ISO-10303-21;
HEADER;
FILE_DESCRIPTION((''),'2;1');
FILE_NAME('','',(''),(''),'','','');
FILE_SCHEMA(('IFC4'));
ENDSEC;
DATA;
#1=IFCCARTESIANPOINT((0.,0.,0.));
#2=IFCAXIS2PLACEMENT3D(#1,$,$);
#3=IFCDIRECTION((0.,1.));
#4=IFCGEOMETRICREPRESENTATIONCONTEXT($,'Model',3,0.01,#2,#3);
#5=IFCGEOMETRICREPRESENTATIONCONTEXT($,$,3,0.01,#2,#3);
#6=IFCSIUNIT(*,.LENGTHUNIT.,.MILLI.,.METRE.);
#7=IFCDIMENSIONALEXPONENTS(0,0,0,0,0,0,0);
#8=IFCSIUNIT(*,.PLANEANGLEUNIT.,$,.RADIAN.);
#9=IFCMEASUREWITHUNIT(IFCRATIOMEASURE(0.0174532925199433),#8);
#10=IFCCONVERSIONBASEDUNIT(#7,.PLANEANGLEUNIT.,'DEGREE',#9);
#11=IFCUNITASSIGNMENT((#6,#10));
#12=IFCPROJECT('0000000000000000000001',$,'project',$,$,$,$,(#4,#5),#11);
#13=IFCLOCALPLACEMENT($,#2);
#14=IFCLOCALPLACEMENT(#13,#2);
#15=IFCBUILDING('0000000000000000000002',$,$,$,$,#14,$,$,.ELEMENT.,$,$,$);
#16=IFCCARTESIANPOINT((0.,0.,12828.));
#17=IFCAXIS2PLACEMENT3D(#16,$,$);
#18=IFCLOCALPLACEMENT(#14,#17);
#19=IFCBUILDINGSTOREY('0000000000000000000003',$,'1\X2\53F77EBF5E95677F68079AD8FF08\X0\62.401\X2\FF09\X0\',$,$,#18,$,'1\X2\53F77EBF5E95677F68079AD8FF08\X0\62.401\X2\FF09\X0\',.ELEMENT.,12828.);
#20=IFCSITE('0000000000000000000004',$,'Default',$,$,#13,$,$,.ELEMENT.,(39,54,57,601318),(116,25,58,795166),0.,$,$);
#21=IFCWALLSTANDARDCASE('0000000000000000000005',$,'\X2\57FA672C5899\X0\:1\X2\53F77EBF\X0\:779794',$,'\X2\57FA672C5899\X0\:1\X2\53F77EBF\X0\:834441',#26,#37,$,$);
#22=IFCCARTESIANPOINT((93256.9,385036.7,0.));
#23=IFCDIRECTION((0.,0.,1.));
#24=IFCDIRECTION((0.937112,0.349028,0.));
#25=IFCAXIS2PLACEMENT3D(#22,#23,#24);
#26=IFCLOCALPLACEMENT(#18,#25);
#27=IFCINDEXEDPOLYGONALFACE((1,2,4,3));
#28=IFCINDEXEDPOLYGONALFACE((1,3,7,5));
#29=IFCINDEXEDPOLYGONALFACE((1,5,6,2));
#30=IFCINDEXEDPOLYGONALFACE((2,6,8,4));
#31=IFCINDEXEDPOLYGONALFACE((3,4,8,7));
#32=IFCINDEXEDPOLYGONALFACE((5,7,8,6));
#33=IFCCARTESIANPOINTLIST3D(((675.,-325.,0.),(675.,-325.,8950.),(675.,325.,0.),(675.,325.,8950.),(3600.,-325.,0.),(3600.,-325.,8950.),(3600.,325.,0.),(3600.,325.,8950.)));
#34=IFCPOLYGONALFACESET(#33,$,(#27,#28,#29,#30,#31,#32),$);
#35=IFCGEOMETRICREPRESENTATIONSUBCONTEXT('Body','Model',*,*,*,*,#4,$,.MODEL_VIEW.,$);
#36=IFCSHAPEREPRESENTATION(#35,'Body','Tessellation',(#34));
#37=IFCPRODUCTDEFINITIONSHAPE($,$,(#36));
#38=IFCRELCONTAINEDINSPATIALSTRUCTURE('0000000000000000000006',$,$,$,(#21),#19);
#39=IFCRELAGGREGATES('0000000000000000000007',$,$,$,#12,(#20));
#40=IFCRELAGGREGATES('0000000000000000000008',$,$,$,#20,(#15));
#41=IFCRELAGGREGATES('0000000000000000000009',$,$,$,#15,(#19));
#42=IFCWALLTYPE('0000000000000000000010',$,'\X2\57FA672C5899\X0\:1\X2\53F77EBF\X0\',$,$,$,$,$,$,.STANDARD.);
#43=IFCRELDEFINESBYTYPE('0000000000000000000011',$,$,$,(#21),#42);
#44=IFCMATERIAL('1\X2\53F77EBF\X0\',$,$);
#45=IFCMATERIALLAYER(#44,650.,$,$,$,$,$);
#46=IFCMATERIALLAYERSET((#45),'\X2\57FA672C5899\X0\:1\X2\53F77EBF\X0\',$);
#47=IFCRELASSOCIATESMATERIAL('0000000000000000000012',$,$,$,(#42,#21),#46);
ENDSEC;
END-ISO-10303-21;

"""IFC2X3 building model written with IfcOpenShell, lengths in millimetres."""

from ifc_helpers import new_model, entity, si_unit, converted_unit, direction, frame, frame_2d, origin, place, context, subcontext, project, spatial, rectangle, extrude, material, layer, layer_set, layer_usage, type_object, element, save


model = new_model("IFC2X3")

# Units and contexts
model_context = context("Model", 3, precision=0.01, world=origin(), true_north=direction((0.0, 1.0)))
context_of_model = context(None, 3, precision=0.01, world=origin(), true_north=direction((0.0, 1.0)))
body_context = subcontext(model_context, "Body", "Model", "MODEL_VIEW")
ifc_project = project(units=[si_unit("LENGTHUNIT", "METRE", prefix="MILLI"), converted_unit("PLANEANGLEUNIT", "DEGREE", entity("IfcRatioMeasure", 0.0174532925199433), si_unit("PLANEANGLEUNIT", "RADIAN"), dimensions=[0, 0, 0, 0, 0, 0, 0])], contexts=[model_context, context_of_model])

# Site, building, storey
site_placement = place(None, origin())
site = spatial("IfcSite", under=ifc_project, at=site_placement, Name="Default", CompositionType="ELEMENT", RefLatitude=(39, 54, 57, 601318), RefLongitude=(116, 25, 58, 795166), RefElevation=0.0)
building_placement = place(site_placement, origin())
building = spatial("IfcBuilding", under=site, at=building_placement, CompositionType="ELEMENT")
storey_placement = place(building_placement, frame((0.0, 0.0, 12828.0)))
storey = spatial("IfcBuildingStorey", under=building, at=storey_placement, Name="1号线底板标高（62.401）", LongName="1号线底板标高（62.401）", CompositionType="ELEMENT", Elevation=12828.0)

# Wall
ifc_material_1 = material(Name="1号线")
ifc_layer = layer(ifc_material_1, 650.0)
ifc_layer_set = layer_set([ifc_layer], Name="基本墙:1号线")
wall_type = type_object("IfcWallType", Name="基本墙:1号线", PredefinedType="STANDARD", material=ifc_layer_set)
ifc_layer_usage_1 = layer_usage(ifc_layer_set, "AXIS2", "NEGATIVE", 325.0)
wall_1_placement = place(storey_placement, frame((93256.9, 385036.7, 0.0), z_axis=(0.0, 0.0, 1.0), x_axis=(0.937112, 0.349028, 0.0)))
element("IfcWallStandardCase", 1, at=wall_1_placement, inside=storey, type_object=wall_type, material=ifc_layer_usage_1, Name="基本墙:1号线:779794", ObjectType="基本墙:1号线:834441", context=body_context, shape_type="SweptSolid", body=[
    extrude(rectangle(XDim=2925.0, YDim=650.0, at=frame_2d((2137.5, 0.0), x_axis=(-1.0, 0.0))), origin(), (0.0, 0.0, 1.0), 8950.0),
])

save(model, "model.ifc")
